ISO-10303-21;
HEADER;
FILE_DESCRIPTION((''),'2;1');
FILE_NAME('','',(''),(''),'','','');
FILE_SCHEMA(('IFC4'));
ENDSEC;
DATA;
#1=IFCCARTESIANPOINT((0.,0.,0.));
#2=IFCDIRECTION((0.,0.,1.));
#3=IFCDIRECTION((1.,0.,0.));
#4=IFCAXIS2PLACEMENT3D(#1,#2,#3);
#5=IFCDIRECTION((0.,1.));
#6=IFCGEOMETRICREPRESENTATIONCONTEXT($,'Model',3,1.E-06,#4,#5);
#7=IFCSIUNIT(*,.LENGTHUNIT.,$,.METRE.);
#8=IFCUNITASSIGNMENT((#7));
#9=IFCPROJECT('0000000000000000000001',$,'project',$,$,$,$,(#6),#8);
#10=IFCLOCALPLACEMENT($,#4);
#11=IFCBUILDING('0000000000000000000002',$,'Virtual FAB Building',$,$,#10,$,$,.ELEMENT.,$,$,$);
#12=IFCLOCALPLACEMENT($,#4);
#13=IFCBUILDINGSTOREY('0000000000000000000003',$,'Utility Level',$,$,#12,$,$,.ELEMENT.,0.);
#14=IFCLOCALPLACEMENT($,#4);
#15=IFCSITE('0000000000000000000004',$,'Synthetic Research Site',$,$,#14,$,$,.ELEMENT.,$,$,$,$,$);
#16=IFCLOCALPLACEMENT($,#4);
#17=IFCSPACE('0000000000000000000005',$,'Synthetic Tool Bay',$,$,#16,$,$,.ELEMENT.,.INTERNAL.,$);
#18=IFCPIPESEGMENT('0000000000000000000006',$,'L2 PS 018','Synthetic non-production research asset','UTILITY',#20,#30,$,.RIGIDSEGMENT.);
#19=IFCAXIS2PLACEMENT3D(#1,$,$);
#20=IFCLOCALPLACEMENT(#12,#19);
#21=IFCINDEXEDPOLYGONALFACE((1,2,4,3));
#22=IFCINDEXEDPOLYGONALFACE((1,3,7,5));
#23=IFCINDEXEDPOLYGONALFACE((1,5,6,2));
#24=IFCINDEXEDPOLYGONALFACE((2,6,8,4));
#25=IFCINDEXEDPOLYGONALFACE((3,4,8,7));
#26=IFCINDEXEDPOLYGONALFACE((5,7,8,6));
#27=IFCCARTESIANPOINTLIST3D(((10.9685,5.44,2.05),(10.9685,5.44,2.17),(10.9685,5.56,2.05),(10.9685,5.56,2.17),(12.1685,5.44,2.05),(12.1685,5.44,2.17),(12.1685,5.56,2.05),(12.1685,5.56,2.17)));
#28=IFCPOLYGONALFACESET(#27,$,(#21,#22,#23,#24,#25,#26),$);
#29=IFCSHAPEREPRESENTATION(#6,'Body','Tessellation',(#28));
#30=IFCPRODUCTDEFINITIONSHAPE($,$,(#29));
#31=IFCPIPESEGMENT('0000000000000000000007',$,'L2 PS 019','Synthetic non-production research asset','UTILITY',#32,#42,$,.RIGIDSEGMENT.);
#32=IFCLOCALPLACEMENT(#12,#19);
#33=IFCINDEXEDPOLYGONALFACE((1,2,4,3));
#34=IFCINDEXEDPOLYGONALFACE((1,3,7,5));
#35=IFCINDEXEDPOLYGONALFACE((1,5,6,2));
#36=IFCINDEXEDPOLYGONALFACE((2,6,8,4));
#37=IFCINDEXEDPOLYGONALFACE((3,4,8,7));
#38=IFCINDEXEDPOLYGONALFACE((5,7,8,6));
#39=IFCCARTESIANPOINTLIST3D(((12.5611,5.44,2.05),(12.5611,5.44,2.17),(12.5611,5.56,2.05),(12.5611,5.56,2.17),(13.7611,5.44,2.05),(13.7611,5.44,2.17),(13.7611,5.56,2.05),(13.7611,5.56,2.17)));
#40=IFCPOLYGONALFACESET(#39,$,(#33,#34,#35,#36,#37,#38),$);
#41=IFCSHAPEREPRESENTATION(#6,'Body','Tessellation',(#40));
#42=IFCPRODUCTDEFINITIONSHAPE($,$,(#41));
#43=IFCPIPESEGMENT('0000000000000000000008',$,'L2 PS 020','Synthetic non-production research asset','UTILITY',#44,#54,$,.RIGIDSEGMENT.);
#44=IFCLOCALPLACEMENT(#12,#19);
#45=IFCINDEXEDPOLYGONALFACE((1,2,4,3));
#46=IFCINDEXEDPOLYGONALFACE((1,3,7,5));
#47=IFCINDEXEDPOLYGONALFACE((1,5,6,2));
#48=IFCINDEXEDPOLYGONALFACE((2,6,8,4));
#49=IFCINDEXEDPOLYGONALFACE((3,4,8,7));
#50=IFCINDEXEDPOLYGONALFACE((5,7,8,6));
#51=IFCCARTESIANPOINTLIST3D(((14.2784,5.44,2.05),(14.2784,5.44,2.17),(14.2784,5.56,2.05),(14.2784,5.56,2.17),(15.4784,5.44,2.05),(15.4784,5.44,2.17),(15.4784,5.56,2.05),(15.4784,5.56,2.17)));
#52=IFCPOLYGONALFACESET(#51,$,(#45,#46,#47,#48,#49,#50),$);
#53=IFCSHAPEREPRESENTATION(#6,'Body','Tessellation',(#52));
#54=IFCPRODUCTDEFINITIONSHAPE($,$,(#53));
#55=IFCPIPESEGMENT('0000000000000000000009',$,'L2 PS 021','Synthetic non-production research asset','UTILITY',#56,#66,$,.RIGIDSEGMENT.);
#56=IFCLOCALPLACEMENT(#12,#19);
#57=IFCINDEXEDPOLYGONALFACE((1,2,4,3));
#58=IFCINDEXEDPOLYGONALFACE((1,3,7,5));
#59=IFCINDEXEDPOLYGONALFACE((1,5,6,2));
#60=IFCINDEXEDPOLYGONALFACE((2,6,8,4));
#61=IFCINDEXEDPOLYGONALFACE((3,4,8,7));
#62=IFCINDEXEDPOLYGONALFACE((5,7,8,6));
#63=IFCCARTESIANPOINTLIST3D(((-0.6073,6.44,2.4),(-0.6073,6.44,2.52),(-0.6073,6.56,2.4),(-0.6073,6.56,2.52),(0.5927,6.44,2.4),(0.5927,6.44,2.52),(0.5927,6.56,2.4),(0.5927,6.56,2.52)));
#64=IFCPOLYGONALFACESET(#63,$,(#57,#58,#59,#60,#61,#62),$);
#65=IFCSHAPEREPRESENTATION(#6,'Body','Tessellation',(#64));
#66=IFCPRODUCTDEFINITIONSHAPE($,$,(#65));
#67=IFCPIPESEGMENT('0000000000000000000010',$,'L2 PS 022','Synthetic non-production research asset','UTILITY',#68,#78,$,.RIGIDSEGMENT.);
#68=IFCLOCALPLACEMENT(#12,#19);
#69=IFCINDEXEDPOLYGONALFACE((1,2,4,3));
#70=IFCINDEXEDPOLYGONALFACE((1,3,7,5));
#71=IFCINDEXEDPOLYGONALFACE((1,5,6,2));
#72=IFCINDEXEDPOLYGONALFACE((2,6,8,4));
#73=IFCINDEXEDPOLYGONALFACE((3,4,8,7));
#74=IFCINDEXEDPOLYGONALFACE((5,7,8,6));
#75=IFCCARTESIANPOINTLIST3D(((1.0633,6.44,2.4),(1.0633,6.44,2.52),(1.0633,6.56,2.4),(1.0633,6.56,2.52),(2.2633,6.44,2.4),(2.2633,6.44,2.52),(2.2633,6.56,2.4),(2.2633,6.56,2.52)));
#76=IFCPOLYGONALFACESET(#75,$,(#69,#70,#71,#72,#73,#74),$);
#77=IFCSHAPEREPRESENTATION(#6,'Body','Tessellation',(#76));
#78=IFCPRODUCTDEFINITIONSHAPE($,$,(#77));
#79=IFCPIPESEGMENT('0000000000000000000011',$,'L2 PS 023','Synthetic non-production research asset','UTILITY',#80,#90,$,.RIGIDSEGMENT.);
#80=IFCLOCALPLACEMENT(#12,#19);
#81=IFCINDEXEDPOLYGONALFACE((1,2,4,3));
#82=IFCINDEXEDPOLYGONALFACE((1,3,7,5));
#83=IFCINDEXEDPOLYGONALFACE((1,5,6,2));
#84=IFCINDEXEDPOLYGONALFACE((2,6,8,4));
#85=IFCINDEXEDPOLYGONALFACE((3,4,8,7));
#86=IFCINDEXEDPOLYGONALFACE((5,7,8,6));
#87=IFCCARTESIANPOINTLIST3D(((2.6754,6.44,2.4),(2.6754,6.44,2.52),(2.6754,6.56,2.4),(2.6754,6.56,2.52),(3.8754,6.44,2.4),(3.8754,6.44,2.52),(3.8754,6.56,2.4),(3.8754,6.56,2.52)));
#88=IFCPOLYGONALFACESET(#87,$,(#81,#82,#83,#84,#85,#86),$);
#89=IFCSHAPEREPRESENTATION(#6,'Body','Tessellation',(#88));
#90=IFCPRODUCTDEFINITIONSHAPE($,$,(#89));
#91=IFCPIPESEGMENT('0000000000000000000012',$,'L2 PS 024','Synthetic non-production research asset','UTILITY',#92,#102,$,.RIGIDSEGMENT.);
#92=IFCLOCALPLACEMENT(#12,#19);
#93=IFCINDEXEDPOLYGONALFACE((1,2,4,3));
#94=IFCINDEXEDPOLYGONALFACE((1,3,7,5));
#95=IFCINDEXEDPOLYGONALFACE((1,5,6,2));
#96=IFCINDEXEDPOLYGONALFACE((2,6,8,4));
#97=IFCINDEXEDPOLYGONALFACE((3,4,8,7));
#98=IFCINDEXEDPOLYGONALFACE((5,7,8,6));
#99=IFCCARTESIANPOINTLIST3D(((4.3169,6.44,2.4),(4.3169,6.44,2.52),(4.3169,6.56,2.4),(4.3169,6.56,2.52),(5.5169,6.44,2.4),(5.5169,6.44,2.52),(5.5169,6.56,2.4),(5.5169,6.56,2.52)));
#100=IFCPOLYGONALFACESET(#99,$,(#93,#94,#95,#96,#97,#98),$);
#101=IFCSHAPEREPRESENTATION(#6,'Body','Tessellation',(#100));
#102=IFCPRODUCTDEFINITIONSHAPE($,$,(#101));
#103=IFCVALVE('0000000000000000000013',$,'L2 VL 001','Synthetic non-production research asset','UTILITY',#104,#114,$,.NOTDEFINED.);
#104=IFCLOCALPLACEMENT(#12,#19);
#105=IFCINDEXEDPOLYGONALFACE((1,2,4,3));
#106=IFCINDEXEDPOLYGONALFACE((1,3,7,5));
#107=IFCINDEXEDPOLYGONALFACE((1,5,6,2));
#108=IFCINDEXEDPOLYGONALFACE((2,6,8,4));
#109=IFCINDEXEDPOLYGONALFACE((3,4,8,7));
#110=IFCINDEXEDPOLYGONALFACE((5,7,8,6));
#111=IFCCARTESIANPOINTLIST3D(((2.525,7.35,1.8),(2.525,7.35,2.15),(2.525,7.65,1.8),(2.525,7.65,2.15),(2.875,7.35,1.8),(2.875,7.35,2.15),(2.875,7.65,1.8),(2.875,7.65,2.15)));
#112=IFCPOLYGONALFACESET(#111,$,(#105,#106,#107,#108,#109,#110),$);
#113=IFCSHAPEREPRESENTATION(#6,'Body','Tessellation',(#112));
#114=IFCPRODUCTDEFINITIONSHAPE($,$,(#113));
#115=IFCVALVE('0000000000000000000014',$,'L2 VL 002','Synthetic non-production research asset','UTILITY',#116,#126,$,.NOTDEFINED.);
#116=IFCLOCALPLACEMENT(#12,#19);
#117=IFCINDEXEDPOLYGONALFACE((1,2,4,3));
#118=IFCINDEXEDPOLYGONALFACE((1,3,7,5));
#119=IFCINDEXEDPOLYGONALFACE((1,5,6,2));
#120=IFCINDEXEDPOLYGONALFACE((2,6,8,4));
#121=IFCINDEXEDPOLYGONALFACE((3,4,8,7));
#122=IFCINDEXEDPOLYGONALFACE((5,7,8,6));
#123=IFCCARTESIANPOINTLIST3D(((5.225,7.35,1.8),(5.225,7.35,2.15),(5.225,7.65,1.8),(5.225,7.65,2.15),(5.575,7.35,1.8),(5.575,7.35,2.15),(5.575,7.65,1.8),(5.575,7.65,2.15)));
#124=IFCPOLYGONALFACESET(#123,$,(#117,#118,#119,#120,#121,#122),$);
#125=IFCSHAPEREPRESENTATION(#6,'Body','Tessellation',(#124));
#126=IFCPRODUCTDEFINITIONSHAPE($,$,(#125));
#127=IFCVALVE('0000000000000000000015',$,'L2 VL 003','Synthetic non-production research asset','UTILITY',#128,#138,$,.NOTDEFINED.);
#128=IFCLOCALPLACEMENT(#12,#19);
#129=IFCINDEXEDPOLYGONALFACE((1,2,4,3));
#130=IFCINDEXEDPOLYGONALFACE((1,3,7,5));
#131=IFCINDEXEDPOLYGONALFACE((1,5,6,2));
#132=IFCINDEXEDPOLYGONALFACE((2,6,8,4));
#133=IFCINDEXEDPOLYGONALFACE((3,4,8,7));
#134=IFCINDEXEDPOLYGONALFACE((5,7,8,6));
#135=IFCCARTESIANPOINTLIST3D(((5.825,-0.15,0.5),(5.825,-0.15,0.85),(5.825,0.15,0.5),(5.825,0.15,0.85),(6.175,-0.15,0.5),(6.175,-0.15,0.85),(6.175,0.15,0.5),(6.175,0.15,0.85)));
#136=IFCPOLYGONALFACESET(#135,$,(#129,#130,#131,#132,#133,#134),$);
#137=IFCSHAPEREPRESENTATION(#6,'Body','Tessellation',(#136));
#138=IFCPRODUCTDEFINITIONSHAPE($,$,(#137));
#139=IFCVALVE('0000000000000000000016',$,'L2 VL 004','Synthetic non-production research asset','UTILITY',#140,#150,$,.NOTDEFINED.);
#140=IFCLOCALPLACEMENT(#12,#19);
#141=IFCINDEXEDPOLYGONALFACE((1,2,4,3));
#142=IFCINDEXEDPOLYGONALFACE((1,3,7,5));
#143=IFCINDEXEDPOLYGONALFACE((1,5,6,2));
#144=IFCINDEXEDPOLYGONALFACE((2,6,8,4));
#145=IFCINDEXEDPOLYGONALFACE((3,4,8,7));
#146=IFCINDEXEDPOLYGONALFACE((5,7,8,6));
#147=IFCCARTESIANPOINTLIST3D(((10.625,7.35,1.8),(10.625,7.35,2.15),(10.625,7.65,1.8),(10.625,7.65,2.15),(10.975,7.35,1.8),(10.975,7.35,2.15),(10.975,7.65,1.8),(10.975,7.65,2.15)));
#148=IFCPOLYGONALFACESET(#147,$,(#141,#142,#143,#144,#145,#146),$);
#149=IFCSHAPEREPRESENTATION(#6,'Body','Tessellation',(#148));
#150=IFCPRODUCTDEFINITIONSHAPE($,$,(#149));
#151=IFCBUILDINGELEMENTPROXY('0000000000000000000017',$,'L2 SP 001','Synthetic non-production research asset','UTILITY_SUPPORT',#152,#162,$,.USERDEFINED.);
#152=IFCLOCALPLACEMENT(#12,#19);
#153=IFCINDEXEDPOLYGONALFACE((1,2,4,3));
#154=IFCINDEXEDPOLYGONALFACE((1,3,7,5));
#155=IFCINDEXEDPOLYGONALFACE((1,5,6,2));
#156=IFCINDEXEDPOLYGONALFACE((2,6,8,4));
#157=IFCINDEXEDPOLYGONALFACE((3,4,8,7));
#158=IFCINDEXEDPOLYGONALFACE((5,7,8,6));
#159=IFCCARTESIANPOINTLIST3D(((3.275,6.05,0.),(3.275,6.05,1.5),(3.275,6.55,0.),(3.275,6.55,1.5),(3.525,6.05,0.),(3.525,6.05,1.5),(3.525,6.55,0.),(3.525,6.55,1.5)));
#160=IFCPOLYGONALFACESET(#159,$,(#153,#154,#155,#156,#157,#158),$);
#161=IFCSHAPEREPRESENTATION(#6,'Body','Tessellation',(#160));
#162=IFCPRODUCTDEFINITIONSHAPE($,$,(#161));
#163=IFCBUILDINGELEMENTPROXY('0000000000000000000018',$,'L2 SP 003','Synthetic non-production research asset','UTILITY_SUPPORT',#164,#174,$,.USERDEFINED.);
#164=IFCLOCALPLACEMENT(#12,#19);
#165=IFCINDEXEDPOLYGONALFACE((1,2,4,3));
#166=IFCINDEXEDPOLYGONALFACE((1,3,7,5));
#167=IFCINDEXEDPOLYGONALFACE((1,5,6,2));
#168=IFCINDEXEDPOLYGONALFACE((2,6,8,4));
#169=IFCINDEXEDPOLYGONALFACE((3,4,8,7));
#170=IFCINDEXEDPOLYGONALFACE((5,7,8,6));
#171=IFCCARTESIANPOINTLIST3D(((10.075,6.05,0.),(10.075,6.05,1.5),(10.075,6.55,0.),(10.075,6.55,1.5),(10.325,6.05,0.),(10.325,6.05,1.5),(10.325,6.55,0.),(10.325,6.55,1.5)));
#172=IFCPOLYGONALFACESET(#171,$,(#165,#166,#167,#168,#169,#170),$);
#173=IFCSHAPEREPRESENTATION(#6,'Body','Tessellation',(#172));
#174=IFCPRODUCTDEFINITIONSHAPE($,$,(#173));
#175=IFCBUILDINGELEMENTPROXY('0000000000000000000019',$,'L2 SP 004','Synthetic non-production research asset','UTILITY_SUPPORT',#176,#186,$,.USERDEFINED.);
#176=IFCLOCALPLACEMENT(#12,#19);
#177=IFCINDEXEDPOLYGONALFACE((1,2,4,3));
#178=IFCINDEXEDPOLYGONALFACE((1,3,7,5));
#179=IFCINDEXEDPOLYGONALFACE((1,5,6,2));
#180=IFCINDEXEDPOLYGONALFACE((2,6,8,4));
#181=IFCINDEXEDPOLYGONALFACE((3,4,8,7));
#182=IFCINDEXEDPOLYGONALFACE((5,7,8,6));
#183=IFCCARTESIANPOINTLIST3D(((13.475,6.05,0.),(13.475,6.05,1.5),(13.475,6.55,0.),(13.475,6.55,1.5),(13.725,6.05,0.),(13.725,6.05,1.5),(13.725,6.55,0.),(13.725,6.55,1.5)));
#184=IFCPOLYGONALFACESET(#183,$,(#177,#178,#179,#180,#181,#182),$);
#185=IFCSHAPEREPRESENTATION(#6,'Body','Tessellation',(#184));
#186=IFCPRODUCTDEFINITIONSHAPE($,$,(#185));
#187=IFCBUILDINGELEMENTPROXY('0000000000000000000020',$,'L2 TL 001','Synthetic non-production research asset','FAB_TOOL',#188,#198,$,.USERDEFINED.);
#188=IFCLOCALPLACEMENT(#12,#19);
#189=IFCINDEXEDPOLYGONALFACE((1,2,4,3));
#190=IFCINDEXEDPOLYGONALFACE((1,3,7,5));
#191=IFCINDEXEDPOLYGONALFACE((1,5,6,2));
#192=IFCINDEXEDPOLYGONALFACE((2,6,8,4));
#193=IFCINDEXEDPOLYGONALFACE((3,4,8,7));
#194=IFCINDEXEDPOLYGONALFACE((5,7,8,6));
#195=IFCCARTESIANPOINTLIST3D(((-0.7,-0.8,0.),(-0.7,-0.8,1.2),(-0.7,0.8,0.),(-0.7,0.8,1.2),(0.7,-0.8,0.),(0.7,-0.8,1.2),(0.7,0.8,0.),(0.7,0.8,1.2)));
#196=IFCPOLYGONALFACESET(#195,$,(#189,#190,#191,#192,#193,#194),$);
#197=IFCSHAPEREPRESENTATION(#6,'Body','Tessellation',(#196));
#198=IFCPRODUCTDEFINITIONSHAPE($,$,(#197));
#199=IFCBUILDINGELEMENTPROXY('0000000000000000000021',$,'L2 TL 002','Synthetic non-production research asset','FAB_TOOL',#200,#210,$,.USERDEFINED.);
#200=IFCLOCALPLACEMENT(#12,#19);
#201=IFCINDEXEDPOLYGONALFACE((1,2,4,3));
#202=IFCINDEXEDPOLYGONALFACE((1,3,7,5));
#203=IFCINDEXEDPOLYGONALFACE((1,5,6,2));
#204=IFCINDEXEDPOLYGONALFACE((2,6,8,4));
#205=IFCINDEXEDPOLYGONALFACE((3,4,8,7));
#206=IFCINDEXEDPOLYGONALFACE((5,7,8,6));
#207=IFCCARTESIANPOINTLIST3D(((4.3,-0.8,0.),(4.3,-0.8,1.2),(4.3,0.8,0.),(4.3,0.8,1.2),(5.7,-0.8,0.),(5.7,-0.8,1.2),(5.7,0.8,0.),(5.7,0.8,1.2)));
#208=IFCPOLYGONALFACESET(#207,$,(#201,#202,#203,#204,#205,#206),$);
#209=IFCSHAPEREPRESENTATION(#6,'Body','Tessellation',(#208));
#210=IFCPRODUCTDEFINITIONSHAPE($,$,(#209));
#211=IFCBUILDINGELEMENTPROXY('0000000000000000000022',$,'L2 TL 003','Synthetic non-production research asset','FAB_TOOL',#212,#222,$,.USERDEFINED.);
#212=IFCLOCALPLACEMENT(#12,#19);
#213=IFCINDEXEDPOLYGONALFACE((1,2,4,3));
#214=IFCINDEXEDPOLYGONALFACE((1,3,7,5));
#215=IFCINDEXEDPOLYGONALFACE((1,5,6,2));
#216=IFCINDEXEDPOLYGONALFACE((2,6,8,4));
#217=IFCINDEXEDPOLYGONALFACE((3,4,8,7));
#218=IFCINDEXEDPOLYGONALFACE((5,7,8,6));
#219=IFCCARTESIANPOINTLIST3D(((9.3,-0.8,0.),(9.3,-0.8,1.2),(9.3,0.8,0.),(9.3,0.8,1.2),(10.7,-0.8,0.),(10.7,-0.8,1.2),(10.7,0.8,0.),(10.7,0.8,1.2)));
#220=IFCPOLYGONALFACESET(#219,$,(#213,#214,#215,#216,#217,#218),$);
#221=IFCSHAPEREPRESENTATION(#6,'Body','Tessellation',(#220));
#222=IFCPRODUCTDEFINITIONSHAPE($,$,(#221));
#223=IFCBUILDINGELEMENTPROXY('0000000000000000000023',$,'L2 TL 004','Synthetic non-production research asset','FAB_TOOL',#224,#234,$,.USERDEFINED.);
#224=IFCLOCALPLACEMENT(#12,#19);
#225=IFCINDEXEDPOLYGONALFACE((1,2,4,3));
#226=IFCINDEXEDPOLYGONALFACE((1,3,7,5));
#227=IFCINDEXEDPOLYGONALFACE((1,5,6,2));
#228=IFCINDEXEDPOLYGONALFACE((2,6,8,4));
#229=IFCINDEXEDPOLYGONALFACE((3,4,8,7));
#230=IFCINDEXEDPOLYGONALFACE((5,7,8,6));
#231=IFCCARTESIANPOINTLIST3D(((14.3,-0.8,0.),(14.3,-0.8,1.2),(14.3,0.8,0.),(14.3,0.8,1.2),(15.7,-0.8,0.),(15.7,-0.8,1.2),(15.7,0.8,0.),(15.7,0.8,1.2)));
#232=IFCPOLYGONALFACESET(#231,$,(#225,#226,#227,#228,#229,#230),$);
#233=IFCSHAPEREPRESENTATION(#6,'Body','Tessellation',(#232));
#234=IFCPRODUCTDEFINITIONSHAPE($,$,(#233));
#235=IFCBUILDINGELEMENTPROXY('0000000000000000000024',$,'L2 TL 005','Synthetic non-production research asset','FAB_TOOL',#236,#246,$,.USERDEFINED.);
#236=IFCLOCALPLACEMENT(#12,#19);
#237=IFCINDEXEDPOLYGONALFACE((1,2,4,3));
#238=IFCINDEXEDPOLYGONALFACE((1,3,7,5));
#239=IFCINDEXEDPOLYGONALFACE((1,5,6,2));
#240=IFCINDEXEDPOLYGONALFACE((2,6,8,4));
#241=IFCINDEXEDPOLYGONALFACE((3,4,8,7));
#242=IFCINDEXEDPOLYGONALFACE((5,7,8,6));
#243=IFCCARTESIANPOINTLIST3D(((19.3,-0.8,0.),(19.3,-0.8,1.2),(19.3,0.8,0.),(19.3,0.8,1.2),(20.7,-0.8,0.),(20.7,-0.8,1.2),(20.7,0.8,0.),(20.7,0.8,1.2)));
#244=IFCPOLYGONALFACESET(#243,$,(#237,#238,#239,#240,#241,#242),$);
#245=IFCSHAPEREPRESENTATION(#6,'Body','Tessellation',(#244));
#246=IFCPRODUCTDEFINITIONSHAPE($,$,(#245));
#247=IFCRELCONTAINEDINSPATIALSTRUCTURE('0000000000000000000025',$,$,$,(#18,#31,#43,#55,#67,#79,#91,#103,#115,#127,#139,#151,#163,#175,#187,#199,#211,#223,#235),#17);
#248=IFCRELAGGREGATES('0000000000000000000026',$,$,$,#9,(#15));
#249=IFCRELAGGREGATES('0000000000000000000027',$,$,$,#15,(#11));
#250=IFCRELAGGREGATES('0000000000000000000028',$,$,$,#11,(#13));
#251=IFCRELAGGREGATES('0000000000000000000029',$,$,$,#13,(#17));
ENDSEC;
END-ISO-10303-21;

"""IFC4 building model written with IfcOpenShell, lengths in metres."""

from ifc_helpers import new_model, si_unit, direction, frame, origin_with_axes, origin_2d_with_axis, place, context, project, spatial, rectangle, extrude, element, save


model = new_model("IFC4")

# Units and contexts
model_context = context("Model", 3, precision=1e-06, world=origin_with_axes(), true_north=direction((0.0, 1.0)))
ifc_project = project(units=[si_unit("LENGTHUNIT", "METRE")], contexts=[model_context])

# Site, building, storey, space
site_placement = place(None, origin_with_axes())
site = spatial("IfcSite", under=ifc_project, at=site_placement, Name="Synthetic Research Site", CompositionType="ELEMENT")
building_placement = place(None, origin_with_axes())
building = spatial("IfcBuilding", under=site, at=building_placement, Name="Virtual FAB Building", CompositionType="ELEMENT")
storey_placement = place(None, origin_with_axes())
storey = spatial("IfcBuildingStorey", under=building, at=storey_placement, Name="Utility Level", CompositionType="ELEMENT", Elevation=0.0)
space_placement = place(None, origin_with_axes())
space = spatial("IfcSpace", under=storey, at=space_placement, Name="Synthetic Tool Bay", CompositionType="ELEMENT", PredefinedType="INTERNAL")

# Pipe segments
for number, where, z_axis, x_axis, name in (
    (1, (11.5685, 5.5, 2.05), (0.0, 0.0, 1.0), (1.0, 0.0, 0.0), "L2 PS 018"),
    (2, (13.1611, 5.5, 2.05), (0.0, 0.0, 1.0), (1.0, 0.0, 0.0), "L2 PS 019"),
    (3, (14.8783, 5.5, 2.05), (0.0, 0.0, 1.0), (1.0, 0.0, 0.0), "L2 PS 020"),
    (4, (-0.0073, 6.5, 2.4), (0.0, 0.0, 1.0), (1.0, 0.0, 0.0), "L2 PS 021"),
    (5, (1.6633, 6.5, 2.4), (0.0, 0.0, 1.0), (1.0, 0.0, 0.0), "L2 PS 022"),
    (6, (3.2754, 6.5, 2.4), (0.0, 0.0, 1.0), (1.0, 0.0, 0.0), "L2 PS 023"),
    (7, (4.9169, 6.5, 2.4), (0.0, 0.0, 1.0), (1.0, 0.0, 0.0), "L2 PS 024"),
):
    element("IfcPipeSegment", number, at=place(None, frame(where, z_axis=z_axis, x_axis=x_axis)), inside=space, Name=name, Description="Synthetic non-production research asset", ObjectType="UTILITY", PredefinedType="RIGIDSEGMENT", context=model_context, shape_type="SweptSolid", body=[
        extrude(rectangle(XDim=1.2, YDim=0.12, at=origin_2d_with_axis()), origin_with_axes(), (0.0, 0.0, 1.0), 0.12),
    ])

# Valves
for number, where, z_axis, x_axis, name in (
    (8, (2.7, 7.5, 1.8), (0.0, 0.0, 1.0), (1.0, 0.0, 0.0), "L2 VL 001"),
    (9, (5.4, 7.5, 1.8), (0.0, 0.0, 1.0), (1.0, 0.0, 0.0), "L2 VL 002"),
    (10, (6.0, 0.0, 0.5), (0.0, 0.0, 1.0), (1.0, 0.0, 0.0), "L2 VL 003"),
    (11, (10.8, 7.5, 1.8), (0.0, 0.0, 1.0), (1.0, 0.0, 0.0), "L2 VL 004"),
):
    element("IfcValve", number, at=place(None, frame(where, z_axis=z_axis, x_axis=x_axis)), inside=space, Name=name, Description="Synthetic non-production research asset", ObjectType="UTILITY", PredefinedType="NOTDEFINED", context=model_context, shape_type="SweptSolid", body=[
        extrude(rectangle(XDim=0.35, YDim=0.3, at=origin_2d_with_axis()), origin_with_axes(), (0.0, 0.0, 1.0), 0.35),
    ])

# Building element proxies
for number, where, z_axis, x_axis, name in (
    (12, (3.4, 6.3, 0.0), (0.0, 0.0, 1.0), (1.0, 0.0, 0.0), "L2 SP 001"),
    (13, (10.2, 6.3, 0.0), (0.0, 0.0, 1.0), (1.0, 0.0, 0.0), "L2 SP 003"),
    (14, (13.6, 6.3, 0.0), (0.0, 0.0, 1.0), (1.0, 0.0, 0.0), "L2 SP 004"),
):
    element("IfcBuildingElementProxy", number, at=place(None, frame(where, z_axis=z_axis, x_axis=x_axis)), inside=space, Name=name, Description="Synthetic non-production research asset", ObjectType="UTILITY_SUPPORT", PredefinedType="USERDEFINED", context=model_context, shape_type="SweptSolid", body=[
        extrude(rectangle(XDim=0.25, YDim=0.5, at=origin_2d_with_axis()), origin_with_axes(), (0.0, 0.0, 1.0), 1.5),
    ])
for number, where, z_axis, x_axis, name in (
    (15, (0.0, 0.0, 0.0), (0.0, 0.0, 1.0), (1.0, 0.0, 0.0), "L2 TL 001"),
    (16, (5.0, 0.0, 0.0), (0.0, 0.0, 1.0), (1.0, 0.0, 0.0), "L2 TL 002"),
    (17, (10.0, 0.0, 0.0), (0.0, 0.0, 1.0), (1.0, 0.0, 0.0), "L2 TL 003"),
    (18, (15.0, 0.0, 0.0), (0.0, 0.0, 1.0), (1.0, 0.0, 0.0), "L2 TL 004"),
    (19, (20.0, 0.0, 0.0), (0.0, 0.0, 1.0), (1.0, 0.0, 0.0), "L2 TL 005"),
):
    element("IfcBuildingElementProxy", number, at=place(None, frame(where, z_axis=z_axis, x_axis=x_axis)), inside=space, Name=name, Description="Synthetic non-production research asset", ObjectType="FAB_TOOL", PredefinedType="USERDEFINED", context=model_context, shape_type="SweptSolid", body=[
        extrude(rectangle(XDim=1.4, YDim=1.6, at=origin_2d_with_axis()), origin_with_axes(), (0.0, 0.0, 1.0), 1.2),
    ])

save(model, "model.ifc")
